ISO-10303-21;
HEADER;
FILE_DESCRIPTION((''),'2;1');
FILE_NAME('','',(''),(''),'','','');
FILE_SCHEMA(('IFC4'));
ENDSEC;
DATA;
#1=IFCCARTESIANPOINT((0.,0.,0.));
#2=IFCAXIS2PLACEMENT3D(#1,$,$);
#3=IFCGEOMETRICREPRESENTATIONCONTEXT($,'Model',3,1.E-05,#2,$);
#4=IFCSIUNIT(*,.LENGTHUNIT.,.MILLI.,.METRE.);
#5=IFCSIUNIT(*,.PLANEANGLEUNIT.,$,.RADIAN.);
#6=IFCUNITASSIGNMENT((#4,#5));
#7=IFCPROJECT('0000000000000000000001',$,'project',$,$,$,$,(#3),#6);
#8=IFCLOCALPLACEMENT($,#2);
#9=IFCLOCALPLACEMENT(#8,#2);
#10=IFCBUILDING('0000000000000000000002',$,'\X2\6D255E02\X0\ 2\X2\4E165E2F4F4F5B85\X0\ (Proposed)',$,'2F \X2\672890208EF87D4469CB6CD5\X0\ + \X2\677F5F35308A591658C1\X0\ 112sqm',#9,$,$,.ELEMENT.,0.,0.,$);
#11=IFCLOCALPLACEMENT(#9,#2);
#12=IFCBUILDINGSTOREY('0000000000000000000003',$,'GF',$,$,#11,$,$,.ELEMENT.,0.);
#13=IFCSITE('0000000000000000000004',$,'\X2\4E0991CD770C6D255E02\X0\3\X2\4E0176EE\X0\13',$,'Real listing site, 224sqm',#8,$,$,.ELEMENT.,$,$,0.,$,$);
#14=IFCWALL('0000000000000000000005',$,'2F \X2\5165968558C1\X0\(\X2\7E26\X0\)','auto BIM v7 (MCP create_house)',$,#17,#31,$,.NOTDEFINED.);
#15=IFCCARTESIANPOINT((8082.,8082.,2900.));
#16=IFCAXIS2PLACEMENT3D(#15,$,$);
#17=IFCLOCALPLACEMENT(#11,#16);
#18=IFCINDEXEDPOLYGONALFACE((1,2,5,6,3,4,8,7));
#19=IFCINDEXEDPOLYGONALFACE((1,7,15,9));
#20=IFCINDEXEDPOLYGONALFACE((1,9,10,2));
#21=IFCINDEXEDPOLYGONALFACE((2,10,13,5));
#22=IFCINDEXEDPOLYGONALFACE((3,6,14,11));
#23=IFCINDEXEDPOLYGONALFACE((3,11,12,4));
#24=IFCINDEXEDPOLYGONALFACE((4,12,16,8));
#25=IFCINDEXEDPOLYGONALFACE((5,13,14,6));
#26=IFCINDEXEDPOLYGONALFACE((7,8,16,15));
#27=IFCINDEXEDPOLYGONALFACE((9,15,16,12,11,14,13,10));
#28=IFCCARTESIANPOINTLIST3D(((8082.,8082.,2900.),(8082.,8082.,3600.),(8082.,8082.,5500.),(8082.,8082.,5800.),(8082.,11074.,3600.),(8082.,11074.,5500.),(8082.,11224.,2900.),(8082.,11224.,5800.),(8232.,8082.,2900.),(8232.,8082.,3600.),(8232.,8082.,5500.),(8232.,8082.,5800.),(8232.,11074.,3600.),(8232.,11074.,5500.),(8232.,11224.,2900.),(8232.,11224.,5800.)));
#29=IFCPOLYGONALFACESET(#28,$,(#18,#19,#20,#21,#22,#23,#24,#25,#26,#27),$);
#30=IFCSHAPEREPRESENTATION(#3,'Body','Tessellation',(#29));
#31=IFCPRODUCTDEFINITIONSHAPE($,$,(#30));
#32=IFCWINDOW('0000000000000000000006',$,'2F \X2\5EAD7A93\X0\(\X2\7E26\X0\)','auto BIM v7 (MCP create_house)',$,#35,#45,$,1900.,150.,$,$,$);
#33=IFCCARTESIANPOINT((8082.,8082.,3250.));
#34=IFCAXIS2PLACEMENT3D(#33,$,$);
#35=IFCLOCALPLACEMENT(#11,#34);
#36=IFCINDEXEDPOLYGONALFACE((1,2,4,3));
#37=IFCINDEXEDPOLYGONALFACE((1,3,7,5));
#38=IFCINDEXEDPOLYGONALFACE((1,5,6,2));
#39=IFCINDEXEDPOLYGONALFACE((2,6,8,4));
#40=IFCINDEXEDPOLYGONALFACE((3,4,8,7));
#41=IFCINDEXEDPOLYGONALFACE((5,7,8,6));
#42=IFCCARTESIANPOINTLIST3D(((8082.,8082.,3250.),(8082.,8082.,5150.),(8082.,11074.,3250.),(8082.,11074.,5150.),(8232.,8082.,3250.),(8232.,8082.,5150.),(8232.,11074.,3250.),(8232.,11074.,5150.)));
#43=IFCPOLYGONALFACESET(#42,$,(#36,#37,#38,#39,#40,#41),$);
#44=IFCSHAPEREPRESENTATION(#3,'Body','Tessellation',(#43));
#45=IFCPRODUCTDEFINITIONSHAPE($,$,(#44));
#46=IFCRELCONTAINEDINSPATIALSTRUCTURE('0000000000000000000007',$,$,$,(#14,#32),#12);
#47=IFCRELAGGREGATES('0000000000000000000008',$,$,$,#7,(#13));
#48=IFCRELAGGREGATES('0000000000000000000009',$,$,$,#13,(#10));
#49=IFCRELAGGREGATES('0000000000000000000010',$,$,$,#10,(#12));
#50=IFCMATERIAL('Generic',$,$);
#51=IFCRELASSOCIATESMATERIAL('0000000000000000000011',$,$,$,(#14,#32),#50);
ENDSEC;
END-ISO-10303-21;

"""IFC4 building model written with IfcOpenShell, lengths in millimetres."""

from ifc_helpers import new_model, si_unit, frame, frame_2d, origin, place, context, project, spatial, rectangle, extrude, material, element, fill, save


model = new_model("IFC4")

# Units and contexts
model_context = context("Model", 3, precision=1e-05, world=origin())
ifc_project = project(units=[si_unit("LENGTHUNIT", "METRE", prefix="MILLI"), si_unit("PLANEANGLEUNIT", "RADIAN")], contexts=[model_context])

# Site, building, storey
site_placement = place(None, origin())
site = spatial("IfcSite", under=ifc_project, at=site_placement, Name="三重県津市3丁目13", ObjectType="Real listing site, 224sqm", CompositionType="ELEMENT", RefElevation=0.0)
building_placement = place(site_placement, origin())
building = spatial("IfcBuilding", under=site, at=building_placement, Name="津市 2世帯住宅 (Proposed)", ObjectType="2F 木造軸組構法 + 板張り外壁 112sqm", CompositionType="ELEMENT", ElevationOfRefHeight=0.0, ElevationOfTerrain=0.0)
storey_placement = place(building_placement, origin())
storey = spatial("IfcBuildingStorey", under=building, at=storey_placement, Name="GF", CompositionType="ELEMENT", Elevation=0.0)

# Shared definitions
ifc_material = material(Name="Generic")

# Wall, opening, window
wall_1_placement = place(storey_placement, frame((8082.0, 8082.0, 2900.0)))
wall_1 = element("IfcWall", 1, at=wall_1_placement, inside=storey, material=ifc_material, Name="2F 入隅壁(縦)", Description="auto BIM v7 (MCP create_house)", PredefinedType="NOTDEFINED", context=model_context, shape_type="SweptSolid", body=[
    extrude(rectangle(XDim=150.0, YDim=3142.0, at=frame_2d((75.0, 1571.0))), frame((8082.0, 8082.0, 2900.0)), (0.0, 0.0, 1.0), 2900.0),
])
opening_1_placement = place(storey_placement, frame((8082.0, 8082.0, 3250.0)))
opening_1 = element("IfcOpeningElement", 2, at=opening_1_placement, cuts=wall_1, PredefinedType="NOTDEFINED", context=model_context, shape_type="SweptSolid", body=[
    extrude(rectangle(XDim=150.0, YDim=2992.0, at=frame_2d((75.0, 1496.0))), frame((8082.0, 8082.0, 3250.0)), (0.0, 0.0, 1.0), 1900.0),
])
window_1_placement = place(storey_placement, frame((8082.0, 8082.0, 3250.0)))
window_1 = element("IfcWindow", 3, at=window_1_placement, inside=storey, material=ifc_material, Name="2F 庭窓(縦)", Description="auto BIM v7 (MCP create_house)", OverallHeight=1900.0, OverallWidth=150.0, context=model_context, shape_type="SweptSolid", body=[
    extrude(rectangle(XDim=150.0, YDim=2992.0, at=frame_2d((75.0, 1496.0))), frame((8082.0, 8082.0, 3250.0)), (0.0, 0.0, 1.0), 1900.0),
])
fill(opening_1, window_1)

save(model, "model.ifc")
